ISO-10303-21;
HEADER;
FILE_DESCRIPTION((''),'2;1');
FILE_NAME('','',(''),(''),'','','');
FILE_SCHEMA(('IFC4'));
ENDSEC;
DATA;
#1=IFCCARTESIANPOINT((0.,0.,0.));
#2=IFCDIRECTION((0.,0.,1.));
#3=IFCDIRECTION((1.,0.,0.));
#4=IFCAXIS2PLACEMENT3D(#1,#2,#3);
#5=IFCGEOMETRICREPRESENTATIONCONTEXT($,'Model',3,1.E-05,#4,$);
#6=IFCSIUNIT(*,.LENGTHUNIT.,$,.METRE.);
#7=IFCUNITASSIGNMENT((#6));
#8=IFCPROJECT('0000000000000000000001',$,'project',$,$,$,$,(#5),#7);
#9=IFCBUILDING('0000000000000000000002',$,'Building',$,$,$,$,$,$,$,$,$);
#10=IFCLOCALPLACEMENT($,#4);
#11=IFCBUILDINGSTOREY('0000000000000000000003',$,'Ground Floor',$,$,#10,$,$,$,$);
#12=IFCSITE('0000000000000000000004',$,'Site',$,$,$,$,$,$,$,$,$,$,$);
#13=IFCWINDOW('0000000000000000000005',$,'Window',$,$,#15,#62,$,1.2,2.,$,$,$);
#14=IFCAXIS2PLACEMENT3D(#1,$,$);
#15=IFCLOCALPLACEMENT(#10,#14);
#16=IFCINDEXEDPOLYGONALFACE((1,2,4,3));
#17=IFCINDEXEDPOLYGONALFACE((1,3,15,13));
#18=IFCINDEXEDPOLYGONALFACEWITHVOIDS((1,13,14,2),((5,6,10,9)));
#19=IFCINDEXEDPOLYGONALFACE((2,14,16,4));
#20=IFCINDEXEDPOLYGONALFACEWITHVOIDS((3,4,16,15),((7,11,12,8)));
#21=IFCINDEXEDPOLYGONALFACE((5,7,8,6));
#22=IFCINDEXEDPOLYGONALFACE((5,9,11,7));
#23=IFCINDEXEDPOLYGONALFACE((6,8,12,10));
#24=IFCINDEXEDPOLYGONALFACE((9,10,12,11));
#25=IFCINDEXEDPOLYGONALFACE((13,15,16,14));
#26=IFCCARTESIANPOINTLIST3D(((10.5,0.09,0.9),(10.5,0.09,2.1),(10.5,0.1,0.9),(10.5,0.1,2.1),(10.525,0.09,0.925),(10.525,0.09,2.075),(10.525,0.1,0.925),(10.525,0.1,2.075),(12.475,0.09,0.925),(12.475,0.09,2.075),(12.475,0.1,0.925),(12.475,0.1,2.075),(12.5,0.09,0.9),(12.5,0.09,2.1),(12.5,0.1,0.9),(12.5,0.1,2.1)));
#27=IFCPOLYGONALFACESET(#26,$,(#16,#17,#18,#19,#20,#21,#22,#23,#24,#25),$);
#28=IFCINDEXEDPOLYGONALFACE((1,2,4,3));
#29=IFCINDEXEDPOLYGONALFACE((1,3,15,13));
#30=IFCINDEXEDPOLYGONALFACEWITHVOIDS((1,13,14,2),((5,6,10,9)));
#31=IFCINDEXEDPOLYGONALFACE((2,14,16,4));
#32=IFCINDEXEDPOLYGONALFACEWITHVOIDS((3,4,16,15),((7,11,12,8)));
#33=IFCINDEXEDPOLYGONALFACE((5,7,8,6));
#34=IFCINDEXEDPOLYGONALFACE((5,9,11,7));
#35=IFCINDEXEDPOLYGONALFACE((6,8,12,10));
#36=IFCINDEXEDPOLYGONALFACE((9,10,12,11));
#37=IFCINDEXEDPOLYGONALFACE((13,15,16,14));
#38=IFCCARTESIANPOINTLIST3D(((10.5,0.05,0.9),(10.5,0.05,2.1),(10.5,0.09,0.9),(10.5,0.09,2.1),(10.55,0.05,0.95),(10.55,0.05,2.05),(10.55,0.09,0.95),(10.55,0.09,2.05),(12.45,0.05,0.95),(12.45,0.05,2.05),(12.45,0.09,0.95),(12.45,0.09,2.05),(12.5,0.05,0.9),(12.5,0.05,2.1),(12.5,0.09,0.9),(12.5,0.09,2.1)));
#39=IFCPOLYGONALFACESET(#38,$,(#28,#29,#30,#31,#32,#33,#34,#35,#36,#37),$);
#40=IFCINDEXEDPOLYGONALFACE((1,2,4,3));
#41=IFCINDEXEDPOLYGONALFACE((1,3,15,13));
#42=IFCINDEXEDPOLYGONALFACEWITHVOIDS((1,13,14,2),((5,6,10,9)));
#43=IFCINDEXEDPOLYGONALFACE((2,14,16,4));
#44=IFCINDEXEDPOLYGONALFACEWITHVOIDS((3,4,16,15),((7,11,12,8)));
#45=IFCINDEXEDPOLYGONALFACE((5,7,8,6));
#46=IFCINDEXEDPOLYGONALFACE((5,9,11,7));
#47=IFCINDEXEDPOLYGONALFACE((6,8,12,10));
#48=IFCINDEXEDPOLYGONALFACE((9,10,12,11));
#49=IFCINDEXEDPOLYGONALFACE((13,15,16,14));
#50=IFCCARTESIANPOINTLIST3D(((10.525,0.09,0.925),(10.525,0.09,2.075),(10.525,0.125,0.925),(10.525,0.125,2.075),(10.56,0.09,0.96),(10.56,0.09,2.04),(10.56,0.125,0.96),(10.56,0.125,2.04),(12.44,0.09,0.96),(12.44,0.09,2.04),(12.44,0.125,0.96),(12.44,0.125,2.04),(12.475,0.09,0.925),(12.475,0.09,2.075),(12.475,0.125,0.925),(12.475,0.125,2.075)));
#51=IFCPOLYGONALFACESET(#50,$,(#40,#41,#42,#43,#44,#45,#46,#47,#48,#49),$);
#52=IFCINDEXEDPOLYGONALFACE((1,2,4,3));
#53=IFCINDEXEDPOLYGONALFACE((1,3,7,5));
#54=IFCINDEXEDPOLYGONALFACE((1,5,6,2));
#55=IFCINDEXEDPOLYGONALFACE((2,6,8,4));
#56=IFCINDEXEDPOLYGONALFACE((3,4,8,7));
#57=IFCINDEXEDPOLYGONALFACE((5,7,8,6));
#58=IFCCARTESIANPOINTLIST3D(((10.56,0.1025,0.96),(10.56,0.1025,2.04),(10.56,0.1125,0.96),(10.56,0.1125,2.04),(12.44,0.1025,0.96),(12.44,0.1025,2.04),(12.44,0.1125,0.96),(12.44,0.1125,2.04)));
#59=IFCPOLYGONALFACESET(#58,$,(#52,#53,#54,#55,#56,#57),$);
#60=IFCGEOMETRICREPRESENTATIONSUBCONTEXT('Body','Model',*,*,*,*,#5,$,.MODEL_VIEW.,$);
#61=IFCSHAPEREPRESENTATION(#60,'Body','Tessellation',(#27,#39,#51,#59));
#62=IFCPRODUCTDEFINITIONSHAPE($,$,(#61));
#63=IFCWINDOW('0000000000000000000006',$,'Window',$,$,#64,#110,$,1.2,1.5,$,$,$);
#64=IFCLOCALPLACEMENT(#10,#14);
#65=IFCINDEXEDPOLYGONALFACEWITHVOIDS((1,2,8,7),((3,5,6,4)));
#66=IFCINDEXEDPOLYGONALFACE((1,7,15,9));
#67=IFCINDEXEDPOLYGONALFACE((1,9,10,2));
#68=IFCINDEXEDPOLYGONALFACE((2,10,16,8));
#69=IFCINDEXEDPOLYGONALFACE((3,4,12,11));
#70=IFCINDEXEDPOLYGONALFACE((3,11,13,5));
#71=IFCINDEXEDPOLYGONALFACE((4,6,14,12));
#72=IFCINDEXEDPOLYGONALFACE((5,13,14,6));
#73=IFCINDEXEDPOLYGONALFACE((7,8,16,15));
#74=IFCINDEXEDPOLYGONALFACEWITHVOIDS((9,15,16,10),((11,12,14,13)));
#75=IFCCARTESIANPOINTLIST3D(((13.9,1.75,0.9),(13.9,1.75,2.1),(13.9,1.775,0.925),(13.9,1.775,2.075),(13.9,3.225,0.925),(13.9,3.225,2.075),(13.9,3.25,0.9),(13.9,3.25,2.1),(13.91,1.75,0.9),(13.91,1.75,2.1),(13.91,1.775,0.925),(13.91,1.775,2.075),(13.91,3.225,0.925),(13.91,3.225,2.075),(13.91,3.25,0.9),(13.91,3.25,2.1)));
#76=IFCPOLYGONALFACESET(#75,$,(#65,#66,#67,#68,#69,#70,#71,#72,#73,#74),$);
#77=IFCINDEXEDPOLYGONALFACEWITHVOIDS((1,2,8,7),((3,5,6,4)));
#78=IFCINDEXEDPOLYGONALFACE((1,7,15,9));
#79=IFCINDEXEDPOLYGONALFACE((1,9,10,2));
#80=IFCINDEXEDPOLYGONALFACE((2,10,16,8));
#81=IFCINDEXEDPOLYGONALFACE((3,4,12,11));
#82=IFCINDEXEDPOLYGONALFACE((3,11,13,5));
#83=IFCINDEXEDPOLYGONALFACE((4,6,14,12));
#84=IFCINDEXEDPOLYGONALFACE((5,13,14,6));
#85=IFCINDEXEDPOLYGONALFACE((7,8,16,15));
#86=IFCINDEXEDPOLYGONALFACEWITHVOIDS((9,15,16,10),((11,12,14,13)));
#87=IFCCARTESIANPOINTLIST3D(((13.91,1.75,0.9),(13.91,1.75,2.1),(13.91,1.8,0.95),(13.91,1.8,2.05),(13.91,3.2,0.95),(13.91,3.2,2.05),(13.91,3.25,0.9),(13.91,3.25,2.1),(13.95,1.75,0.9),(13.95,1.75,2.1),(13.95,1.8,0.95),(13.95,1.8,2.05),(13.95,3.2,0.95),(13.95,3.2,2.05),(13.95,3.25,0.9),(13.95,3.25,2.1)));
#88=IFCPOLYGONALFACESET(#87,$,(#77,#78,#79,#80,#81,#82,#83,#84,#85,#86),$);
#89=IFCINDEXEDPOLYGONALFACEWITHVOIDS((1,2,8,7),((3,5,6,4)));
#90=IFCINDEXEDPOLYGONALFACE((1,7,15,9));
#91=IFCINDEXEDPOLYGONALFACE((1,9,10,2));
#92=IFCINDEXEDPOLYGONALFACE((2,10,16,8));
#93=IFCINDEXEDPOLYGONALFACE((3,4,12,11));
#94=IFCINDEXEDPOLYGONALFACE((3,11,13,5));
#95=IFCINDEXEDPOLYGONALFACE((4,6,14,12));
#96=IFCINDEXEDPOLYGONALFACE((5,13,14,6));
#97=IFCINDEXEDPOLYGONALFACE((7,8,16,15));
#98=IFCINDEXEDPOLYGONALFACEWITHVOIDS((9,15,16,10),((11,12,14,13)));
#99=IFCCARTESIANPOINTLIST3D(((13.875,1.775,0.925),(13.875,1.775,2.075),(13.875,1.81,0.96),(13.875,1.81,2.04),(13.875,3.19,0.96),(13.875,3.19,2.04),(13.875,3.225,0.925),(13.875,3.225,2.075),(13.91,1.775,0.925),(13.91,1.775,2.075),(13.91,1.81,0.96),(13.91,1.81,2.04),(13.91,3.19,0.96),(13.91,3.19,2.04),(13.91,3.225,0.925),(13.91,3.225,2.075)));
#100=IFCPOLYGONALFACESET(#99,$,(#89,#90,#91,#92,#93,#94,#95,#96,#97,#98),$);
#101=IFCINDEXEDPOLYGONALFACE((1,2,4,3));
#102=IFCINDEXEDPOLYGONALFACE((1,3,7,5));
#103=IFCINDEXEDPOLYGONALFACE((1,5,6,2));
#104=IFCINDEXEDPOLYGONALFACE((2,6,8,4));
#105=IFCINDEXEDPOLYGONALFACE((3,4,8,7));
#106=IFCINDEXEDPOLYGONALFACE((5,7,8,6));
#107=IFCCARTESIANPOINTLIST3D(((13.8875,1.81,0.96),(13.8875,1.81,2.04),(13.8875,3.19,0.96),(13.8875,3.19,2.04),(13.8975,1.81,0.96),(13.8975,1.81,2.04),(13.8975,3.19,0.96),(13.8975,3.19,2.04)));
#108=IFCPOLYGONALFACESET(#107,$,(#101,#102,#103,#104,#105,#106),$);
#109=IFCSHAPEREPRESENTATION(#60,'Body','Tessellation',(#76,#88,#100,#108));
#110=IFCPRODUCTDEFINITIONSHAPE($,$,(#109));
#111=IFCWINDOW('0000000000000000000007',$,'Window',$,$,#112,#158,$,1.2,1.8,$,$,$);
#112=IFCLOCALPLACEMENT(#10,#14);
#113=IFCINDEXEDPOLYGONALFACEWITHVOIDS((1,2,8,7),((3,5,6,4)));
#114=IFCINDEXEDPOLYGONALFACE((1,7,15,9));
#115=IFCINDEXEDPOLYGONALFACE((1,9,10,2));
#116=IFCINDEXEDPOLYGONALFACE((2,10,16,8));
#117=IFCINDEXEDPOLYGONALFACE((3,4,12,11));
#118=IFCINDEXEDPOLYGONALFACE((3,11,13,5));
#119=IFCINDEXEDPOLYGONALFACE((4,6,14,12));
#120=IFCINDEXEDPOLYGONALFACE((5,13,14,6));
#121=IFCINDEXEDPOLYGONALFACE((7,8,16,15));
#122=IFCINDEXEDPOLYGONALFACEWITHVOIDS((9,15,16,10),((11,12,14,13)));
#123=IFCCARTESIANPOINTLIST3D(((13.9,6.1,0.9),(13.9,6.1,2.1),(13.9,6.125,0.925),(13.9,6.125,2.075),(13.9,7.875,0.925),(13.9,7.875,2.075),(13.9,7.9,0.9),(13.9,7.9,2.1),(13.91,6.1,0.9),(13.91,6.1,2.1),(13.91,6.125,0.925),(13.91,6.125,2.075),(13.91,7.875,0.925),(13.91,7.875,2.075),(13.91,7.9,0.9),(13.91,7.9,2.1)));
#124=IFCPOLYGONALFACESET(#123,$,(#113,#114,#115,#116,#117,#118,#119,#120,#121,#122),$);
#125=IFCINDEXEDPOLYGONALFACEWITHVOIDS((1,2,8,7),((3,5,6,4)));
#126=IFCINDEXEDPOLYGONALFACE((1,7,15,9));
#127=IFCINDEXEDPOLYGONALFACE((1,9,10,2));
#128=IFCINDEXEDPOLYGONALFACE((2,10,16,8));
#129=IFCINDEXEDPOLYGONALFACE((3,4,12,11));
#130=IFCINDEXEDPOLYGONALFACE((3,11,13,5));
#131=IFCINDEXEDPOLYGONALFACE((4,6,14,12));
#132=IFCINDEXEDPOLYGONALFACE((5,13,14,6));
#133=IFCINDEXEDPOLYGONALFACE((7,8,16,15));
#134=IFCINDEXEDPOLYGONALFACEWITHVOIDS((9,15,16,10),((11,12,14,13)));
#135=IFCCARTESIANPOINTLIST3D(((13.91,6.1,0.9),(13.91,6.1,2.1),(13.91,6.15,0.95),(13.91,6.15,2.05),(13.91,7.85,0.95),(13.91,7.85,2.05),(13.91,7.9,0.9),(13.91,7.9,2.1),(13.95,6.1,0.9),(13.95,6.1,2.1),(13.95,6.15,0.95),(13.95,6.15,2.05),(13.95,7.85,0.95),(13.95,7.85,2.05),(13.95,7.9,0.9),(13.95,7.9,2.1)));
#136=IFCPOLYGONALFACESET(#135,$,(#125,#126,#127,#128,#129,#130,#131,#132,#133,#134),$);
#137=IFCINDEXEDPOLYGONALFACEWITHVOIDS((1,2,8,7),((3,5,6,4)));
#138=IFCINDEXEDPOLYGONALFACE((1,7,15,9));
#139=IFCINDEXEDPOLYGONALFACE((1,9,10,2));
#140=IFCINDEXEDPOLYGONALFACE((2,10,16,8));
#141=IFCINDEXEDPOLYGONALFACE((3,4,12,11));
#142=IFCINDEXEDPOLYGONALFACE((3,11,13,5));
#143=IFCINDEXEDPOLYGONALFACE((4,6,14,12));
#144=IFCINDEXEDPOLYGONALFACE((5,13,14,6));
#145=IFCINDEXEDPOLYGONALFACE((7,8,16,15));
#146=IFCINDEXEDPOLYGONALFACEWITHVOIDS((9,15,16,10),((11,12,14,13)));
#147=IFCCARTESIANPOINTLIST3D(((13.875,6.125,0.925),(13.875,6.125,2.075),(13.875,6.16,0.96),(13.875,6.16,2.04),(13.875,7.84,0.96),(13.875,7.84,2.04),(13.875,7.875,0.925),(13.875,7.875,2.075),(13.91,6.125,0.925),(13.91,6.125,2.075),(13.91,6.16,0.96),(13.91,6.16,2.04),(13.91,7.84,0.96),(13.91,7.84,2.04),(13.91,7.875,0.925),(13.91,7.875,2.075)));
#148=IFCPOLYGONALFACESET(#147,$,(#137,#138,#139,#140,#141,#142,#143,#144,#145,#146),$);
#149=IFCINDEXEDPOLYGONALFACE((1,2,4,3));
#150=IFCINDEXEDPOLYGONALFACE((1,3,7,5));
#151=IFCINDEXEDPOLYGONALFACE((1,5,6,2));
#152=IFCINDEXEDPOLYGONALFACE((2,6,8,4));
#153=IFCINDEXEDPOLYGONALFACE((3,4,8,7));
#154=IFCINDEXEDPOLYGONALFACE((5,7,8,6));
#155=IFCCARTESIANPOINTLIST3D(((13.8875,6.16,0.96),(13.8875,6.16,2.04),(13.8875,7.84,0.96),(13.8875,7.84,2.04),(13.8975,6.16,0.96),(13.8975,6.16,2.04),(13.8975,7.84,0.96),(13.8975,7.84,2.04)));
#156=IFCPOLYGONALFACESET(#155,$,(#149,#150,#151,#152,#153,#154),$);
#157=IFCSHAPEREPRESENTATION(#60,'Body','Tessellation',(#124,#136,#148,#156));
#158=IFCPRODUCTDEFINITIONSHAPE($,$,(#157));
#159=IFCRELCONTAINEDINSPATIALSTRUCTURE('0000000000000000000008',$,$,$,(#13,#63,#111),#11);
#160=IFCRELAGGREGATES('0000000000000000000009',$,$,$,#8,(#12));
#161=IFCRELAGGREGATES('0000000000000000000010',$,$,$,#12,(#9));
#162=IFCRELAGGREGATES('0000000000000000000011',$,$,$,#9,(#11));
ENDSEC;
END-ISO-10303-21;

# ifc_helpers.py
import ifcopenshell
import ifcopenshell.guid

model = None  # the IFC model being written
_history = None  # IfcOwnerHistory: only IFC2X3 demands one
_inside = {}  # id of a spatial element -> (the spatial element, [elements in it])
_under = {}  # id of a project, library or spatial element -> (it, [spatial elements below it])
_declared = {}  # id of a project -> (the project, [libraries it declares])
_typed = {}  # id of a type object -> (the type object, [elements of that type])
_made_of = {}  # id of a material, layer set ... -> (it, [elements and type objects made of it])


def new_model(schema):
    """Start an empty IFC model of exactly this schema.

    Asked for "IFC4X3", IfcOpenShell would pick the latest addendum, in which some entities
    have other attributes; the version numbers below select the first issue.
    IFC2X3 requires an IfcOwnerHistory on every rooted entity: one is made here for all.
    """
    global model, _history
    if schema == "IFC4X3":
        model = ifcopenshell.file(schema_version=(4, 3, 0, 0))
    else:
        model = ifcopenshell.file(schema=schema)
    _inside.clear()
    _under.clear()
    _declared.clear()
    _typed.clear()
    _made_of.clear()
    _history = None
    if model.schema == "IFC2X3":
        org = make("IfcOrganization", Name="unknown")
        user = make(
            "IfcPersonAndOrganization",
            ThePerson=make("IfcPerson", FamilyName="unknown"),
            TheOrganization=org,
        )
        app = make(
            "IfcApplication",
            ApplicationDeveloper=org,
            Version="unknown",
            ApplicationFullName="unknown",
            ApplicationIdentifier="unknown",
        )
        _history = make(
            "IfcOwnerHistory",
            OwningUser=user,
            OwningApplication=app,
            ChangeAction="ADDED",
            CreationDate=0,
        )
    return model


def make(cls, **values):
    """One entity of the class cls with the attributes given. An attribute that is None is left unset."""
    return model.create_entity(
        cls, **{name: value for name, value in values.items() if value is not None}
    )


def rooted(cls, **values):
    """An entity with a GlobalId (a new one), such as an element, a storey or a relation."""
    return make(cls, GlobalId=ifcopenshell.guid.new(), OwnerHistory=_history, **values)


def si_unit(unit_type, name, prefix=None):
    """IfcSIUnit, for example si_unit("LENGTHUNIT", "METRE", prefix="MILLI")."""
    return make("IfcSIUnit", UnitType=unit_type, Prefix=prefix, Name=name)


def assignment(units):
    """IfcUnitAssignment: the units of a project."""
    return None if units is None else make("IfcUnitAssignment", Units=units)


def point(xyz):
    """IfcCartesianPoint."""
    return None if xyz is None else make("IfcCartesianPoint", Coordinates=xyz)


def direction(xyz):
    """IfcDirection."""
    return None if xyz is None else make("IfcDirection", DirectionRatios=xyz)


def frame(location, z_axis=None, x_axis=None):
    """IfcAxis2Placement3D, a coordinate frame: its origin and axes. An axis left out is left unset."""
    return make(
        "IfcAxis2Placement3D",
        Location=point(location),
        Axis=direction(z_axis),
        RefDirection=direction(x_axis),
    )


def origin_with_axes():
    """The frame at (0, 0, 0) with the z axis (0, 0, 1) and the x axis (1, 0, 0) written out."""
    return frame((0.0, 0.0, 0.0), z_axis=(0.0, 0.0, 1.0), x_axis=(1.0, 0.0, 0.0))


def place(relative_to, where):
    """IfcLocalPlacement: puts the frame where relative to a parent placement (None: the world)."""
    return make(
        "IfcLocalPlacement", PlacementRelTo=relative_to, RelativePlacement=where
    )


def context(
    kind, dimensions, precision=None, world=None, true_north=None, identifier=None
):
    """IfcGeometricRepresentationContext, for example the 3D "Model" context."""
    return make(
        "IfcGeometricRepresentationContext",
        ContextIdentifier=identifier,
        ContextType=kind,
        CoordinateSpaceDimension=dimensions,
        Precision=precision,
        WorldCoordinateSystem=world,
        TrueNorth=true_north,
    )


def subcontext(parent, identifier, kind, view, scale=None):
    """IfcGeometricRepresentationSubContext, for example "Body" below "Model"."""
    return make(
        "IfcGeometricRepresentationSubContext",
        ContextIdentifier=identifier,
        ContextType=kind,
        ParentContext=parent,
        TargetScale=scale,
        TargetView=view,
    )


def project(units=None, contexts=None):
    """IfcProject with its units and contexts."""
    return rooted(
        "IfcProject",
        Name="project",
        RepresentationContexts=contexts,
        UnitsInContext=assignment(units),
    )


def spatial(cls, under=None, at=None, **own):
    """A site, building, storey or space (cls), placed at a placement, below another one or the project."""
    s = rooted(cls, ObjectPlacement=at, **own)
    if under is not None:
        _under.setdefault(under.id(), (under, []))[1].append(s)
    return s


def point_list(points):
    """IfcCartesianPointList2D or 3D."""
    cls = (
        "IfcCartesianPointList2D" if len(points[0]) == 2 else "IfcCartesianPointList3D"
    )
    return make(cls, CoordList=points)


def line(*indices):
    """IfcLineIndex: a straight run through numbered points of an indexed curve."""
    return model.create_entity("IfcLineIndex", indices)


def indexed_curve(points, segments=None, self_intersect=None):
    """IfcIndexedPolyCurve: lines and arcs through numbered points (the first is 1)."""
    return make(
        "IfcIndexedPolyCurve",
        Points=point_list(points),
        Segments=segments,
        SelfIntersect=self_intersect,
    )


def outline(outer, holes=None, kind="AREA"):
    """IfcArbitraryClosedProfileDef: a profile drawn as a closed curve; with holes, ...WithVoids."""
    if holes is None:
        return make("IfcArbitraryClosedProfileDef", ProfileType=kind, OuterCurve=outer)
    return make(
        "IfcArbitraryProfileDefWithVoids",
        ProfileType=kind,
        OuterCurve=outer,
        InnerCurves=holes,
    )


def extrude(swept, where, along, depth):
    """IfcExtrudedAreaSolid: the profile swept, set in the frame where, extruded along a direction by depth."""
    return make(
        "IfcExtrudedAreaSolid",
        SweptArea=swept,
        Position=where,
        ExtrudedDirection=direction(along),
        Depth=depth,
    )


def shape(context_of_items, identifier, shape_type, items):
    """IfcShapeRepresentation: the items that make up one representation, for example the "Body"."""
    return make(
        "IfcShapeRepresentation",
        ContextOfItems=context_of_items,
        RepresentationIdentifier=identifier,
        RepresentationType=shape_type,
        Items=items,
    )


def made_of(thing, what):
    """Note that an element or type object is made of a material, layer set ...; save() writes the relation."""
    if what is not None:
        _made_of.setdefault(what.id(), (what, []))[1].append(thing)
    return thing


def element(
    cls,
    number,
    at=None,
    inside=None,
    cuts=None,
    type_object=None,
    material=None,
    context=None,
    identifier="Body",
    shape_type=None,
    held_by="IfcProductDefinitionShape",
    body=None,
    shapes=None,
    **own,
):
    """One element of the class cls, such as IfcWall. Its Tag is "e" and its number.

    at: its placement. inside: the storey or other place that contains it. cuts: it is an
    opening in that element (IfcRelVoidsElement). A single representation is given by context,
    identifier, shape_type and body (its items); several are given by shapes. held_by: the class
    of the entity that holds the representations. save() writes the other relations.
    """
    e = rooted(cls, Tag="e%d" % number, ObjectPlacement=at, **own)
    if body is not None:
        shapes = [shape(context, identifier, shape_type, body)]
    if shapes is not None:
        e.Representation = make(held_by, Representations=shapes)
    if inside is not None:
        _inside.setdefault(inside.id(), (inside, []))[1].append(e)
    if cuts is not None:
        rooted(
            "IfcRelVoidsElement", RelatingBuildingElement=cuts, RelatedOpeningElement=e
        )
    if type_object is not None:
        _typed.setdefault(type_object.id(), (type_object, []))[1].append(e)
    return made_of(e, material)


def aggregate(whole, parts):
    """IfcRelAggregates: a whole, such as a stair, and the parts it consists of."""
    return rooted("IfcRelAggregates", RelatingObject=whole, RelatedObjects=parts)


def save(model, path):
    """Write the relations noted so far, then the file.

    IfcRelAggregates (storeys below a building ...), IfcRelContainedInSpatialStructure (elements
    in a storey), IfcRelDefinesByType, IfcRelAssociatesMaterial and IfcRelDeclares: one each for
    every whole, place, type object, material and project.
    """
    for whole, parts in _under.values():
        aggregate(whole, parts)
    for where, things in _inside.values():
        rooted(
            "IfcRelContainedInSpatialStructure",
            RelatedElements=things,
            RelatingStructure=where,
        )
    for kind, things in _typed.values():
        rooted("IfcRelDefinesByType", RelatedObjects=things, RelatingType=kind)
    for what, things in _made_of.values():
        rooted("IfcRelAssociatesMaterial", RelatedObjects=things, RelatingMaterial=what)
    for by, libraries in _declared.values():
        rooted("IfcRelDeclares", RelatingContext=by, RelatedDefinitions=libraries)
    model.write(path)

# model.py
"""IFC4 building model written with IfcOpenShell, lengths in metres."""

from ifc_helpers import new_model, si_unit, frame, origin_with_axes, place, context, subcontext, project, spatial, line, indexed_curve, outline, extrude, element, save


model = new_model("IFC4")

# Units and contexts
model_context = context("Model", 3, precision=1e-05, world=origin_with_axes())
body_context = subcontext(model_context, "Body", "Model", "MODEL_VIEW")
ifc_project = project(units=[si_unit("LENGTHUNIT", "METRE")], contexts=[model_context])

# Site, building, storey
site = spatial("IfcSite", under=ifc_project, Name="Site")
building = spatial("IfcBuilding", under=site, Name="Building")
storey_placement = place(None, origin_with_axes())
storey = spatial("IfcBuildingStorey", under=building, at=storey_placement, Name="Ground Floor")

# Windows
window_1_placement = place(storey_placement, frame((10.5, 0.0, 0.9), z_axis=(0.0, 0.0, 1.0), x_axis=(1.0, 0.0, 0.0)))
element("IfcWindow", 1, at=window_1_placement, inside=storey, Name="Window", OverallHeight=1.2, OverallWidth=2.0, context=body_context, shape_type="SweptSolid", body=[
    extrude(outline(indexed_curve([(0.0, 0.0), (2.0, 0.0), (2.0, 1.2), (0.0, 1.2)], segments=[line(1, 2, 3, 4, 1)]), holes=[indexed_curve([(0.025, 0.025), (1.975, 0.025), (1.975, 1.175), (0.025, 1.175)], segments=[line(1, 2, 3, 4, 1)])]), frame((0.0, 0.09, 0.0), z_axis=(0.0, -1.0, 0.0), x_axis=(1.0, 0.0, 0.0)), (0.0, 0.0, -1.0), 0.01),
    extrude(outline(indexed_curve([(0.0, 0.0), (2.0, 0.0), (2.0, 1.2), (0.0, 1.2)], segments=[line(1, 2, 3, 4, 1)]), holes=[indexed_curve([(0.05, 0.05), (1.95, 0.05), (1.95, 1.15), (0.05, 1.15)], segments=[line(1, 2, 3, 4, 1)])]), frame((0.0, 0.05, 0.0), z_axis=(0.0, -1.0, 0.0), x_axis=(1.0, 0.0, 0.0)), (0.0, 0.0, -1.0), 0.04),
    extrude(outline(indexed_curve([(0.0, 0.0), (1.95, 0.0), (1.95, 1.15), (0.0, 1.15)], segments=[line(1, 2, 3, 4, 1)]), holes=[indexed_curve([(0.035, 0.035), (1.915, 0.035), (1.915, 1.115), (0.035, 1.115)], segments=[line(1, 2, 3, 4, 1)])]), frame((0.025, 0.09, 0.025), z_axis=(0.0, -1.0, 0.0), x_axis=(1.0, 0.0, 0.0)), (0.0, 0.0, -1.0), 0.035),
    extrude(outline(indexed_curve([(0.035, 0.035), (1.915, 0.035), (1.915, 1.115), (0.035, 1.115)], segments=[line(1, 2, 3, 4, 1)])), frame((0.025, 0.1025, 0.025), z_axis=(0.0, -1.0, 0.0), x_axis=(1.0, 0.0, 0.0)), (0.0, 0.0, -1.0), 0.01),
])
window_2_placement = place(storey_placement, frame((14.0, 1.75, 0.9), z_axis=(0.0, 0.0, 1.0), x_axis=(0.0, 1.0, 0.0)))
element("IfcWindow", 2, at=window_2_placement, inside=storey, Name="Window", OverallHeight=1.2, OverallWidth=1.5, context=body_context, shape_type="SweptSolid", body=[
    extrude(outline(indexed_curve([(0.0, 0.0), (1.5, 0.0), (1.5, 1.2), (0.0, 1.2)], segments=[line(1, 2, 3, 4, 1)]), holes=[indexed_curve([(0.025, 0.025), (1.475, 0.025), (1.475, 1.175), (0.025, 1.175)], segments=[line(1, 2, 3, 4, 1)])]), frame((0.0, 0.09, 0.0), z_axis=(0.0, -1.0, 0.0), x_axis=(1.0, 0.0, 0.0)), (0.0, 0.0, -1.0), 0.01),
    extrude(outline(indexed_curve([(0.0, 0.0), (1.5, 0.0), (1.5, 1.2), (0.0, 1.2)], segments=[line(1, 2, 3, 4, 1)]), holes=[indexed_curve([(0.05, 0.05), (1.45, 0.05), (1.45, 1.15), (0.05, 1.15)], segments=[line(1, 2, 3, 4, 1)])]), frame((0.0, 0.05, 0.0), z_axis=(0.0, -1.0, 0.0), x_axis=(1.0, 0.0, 0.0)), (0.0, 0.0, -1.0), 0.04),
    extrude(outline(indexed_curve([(0.0, 0.0), (1.45, 0.0), (1.45, 1.15), (0.0, 1.15)], segments=[line(1, 2, 3, 4, 1)]), holes=[indexed_curve([(0.035, 0.035), (1.415, 0.035), (1.415, 1.115), (0.035, 1.115)], segments=[line(1, 2, 3, 4, 1)])]), frame((0.025, 0.09, 0.025), z_axis=(0.0, -1.0, 0.0), x_axis=(1.0, 0.0, 0.0)), (0.0, 0.0, -1.0), 0.035),
    extrude(outline(indexed_curve([(0.035, 0.035), (1.415, 0.035), (1.415, 1.115), (0.035, 1.115)], segments=[line(1, 2, 3, 4, 1)])), frame((0.025, 0.1025, 0.025), z_axis=(0.0, -1.0, 0.0), x_axis=(1.0, 0.0, 0.0)), (0.0, 0.0, -1.0), 0.01),
])
window_3_placement = place(storey_placement, frame((14.0, 6.1, 0.9), z_axis=(0.0, 0.0, 1.0), x_axis=(0.0, 1.0, 0.0)))
element("IfcWindow", 3, at=window_3_placement, inside=storey, Name="Window", OverallHeight=1.2, OverallWidth=1.8, context=body_context, shape_type="SweptSolid", body=[
    extrude(outline(indexed_curve([(0.0, 0.0), (1.8, 0.0), (1.8, 1.2), (0.0, 1.2)], segments=[line(1, 2, 3, 4, 1)]), holes=[indexed_curve([(0.025, 0.025), (1.775, 0.025), (1.775, 1.175), (0.025, 1.175)], segments=[line(1, 2, 3, 4, 1)])]), frame((0.0, 0.09, 0.0), z_axis=(0.0, -1.0, 0.0), x_axis=(1.0, 0.0, 0.0)), (0.0, 0.0, -1.0), 0.01),
    extrude(outline(indexed_curve([(0.0, 0.0), (1.8, 0.0), (1.8, 1.2), (0.0, 1.2)], segments=[line(1, 2, 3, 4, 1)]), holes=[indexed_curve([(0.05, 0.05), (1.75, 0.05), (1.75, 1.15), (0.05, 1.15)], segments=[line(1, 2, 3, 4, 1)])]), frame((0.0, 0.05, 0.0), z_axis=(0.0, -1.0, 0.0), x_axis=(1.0, 0.0, 0.0)), (0.0, 0.0, -1.0), 0.04),
    extrude(outline(indexed_curve([(0.0, 0.0), (1.75, 0.0), (1.75, 1.15), (0.0, 1.15)], segments=[line(1, 2, 3, 4, 1)]), holes=[indexed_curve([(0.035, 0.035), (1.715, 0.035), (1.715, 1.115), (0.035, 1.115)], segments=[line(1, 2, 3, 4, 1)])]), frame((0.025, 0.09, 0.025), z_axis=(0.0, -1.0, 0.0), x_axis=(1.0, 0.0, 0.0)), (0.0, 0.0, -1.0), 0.035),
    extrude(outline(indexed_curve([(0.035, 0.035), (1.715, 0.035), (1.715, 1.115), (0.035, 1.115)], segments=[line(1, 2, 3, 4, 1)])), frame((0.025, 0.1025, 0.025), z_axis=(0.0, -1.0, 0.0), x_axis=(1.0, 0.0, 0.0)), (0.0, 0.0, -1.0), 0.01),
])

save(model, "model.ifc")
